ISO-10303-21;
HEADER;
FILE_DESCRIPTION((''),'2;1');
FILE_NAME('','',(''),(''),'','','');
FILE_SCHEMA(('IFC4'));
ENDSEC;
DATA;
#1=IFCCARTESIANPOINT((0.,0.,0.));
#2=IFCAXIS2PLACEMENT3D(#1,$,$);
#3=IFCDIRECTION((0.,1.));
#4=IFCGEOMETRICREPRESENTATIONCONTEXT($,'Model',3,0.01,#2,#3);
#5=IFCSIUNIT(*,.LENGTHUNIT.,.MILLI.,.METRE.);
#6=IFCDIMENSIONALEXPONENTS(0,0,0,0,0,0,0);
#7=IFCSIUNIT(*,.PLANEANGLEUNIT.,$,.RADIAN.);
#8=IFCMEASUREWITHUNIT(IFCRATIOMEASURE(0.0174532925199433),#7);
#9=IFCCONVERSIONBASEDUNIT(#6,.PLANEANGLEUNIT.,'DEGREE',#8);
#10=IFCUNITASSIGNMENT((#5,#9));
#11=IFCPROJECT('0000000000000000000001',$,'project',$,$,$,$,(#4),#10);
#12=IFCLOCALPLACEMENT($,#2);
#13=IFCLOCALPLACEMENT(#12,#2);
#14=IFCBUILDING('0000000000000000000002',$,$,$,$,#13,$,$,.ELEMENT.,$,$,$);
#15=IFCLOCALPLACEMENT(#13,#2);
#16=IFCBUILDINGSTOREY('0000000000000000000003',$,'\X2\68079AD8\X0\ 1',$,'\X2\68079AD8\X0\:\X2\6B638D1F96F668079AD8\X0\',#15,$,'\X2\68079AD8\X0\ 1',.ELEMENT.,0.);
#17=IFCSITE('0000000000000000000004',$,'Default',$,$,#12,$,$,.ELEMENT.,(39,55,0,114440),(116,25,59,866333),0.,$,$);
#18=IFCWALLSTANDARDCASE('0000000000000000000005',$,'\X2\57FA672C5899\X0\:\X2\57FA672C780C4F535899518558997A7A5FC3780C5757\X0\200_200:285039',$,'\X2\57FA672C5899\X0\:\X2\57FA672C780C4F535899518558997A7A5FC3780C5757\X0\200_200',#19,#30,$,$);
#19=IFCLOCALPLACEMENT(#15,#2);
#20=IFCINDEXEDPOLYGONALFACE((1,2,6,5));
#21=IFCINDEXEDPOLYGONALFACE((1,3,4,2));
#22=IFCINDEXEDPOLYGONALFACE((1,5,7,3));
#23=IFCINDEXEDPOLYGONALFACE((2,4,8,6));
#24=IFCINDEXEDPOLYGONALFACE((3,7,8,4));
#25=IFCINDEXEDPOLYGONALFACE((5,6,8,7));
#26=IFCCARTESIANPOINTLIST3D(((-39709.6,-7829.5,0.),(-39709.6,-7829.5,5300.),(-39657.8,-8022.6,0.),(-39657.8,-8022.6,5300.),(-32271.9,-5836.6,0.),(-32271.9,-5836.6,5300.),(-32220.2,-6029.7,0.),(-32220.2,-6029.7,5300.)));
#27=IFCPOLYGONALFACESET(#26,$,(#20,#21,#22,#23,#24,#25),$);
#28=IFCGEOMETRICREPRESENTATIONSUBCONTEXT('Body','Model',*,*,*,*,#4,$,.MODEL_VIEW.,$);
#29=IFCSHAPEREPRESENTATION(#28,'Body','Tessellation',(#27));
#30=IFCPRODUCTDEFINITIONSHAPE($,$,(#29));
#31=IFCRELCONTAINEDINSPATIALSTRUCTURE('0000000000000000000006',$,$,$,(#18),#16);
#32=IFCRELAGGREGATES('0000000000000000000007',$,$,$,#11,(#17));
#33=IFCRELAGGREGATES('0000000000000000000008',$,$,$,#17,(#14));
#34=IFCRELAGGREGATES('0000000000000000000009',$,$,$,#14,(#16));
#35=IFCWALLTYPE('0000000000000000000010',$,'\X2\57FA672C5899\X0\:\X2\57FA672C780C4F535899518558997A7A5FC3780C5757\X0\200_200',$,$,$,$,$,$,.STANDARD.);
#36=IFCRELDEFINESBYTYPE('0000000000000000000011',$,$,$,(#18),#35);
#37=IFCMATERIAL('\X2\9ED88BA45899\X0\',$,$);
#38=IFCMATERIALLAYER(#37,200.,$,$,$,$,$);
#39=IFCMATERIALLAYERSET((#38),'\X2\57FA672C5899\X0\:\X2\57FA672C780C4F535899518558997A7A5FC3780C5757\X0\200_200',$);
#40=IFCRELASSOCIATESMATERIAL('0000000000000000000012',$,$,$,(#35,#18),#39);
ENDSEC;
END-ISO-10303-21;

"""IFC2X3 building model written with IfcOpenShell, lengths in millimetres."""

from ifc_helpers import new_model, entity, si_unit, converted_unit, direction, frame, frame_2d, origin, place, context, subcontext, project, spatial, rectangle, extrude, material, layer, layer_set, layer_usage, type_object, element, save


model = new_model("IFC2X3")

# Units and contexts
model_context = context("Model", 3, precision=0.01, world=origin(), true_north=direction((0.0, 1.0)))
body_context = subcontext(model_context, "Body", "Model", "MODEL_VIEW")
ifc_project = project(units=[si_unit("LENGTHUNIT", "METRE", prefix="MILLI"), converted_unit("PLANEANGLEUNIT", "DEGREE", entity("IfcRatioMeasure", 0.0174532925199433), si_unit("PLANEANGLEUNIT", "RADIAN"), dimensions=[0, 0, 0, 0, 0, 0, 0])], contexts=[model_context])

# Site, building, storey
site_placement = place(None, origin())
site = spatial("IfcSite", under=ifc_project, at=site_placement, Name="Default", CompositionType="ELEMENT", RefLatitude=(39, 55, 0, 114440), RefLongitude=(116, 25, 59, 866333), RefElevation=0.0)
building_placement = place(site_placement, origin())
building = spatial("IfcBuilding", under=site, at=building_placement, CompositionType="ELEMENT")
storey_placement = place(building_placement, origin())
storey = spatial("IfcBuildingStorey", under=building, at=storey_placement, Name="标高 1", ObjectType="标高:正负零标高", LongName="标高 1", CompositionType="ELEMENT", Elevation=0.0)

# Wall
ifc_material_1 = material(Name="默认墙")
ifc_layer_1 = layer(ifc_material_1, 200.0)
ifc_layer_set_1 = layer_set([ifc_layer_1], Name="基本墙:基本砌体墙内墙空心砌块200_200")
wall_type_1 = type_object("IfcWallType", Name="基本墙:基本砌体墙内墙空心砌块200_200", PredefinedType="STANDARD", material=ifc_layer_set_1)
ifc_layer_usage_1 = layer_usage(ifc_layer_set_1, "AXIS2", "NEGATIVE", 100.0)
wall_1_placement = place(building_placement, frame((-32246.1, -5933.2, 0.0), z_axis=(0.0, 0.0, 1.0), x_axis=(-0.965926, -0.258819, 0.0)))
element("IfcWallStandardCase", 1, at=wall_1_placement, inside=storey, type_object=wall_type_1, material=ifc_layer_usage_1, Name="基本墙:基本砌体墙内墙空心砌块200_200:285039", ObjectType="基本墙:基本砌体墙内墙空心砌块200_200", context=body_context, shape_type="SweptSolid", body=[
    extrude(rectangle(XDim=7700.0, YDim=200.0, at=frame_2d((3850.0, 0.0), x_axis=(-1.0, 0.0))), origin(), (0.0, 0.0, 1.0), 5300.0),
])

save(model, "model.ifc")
